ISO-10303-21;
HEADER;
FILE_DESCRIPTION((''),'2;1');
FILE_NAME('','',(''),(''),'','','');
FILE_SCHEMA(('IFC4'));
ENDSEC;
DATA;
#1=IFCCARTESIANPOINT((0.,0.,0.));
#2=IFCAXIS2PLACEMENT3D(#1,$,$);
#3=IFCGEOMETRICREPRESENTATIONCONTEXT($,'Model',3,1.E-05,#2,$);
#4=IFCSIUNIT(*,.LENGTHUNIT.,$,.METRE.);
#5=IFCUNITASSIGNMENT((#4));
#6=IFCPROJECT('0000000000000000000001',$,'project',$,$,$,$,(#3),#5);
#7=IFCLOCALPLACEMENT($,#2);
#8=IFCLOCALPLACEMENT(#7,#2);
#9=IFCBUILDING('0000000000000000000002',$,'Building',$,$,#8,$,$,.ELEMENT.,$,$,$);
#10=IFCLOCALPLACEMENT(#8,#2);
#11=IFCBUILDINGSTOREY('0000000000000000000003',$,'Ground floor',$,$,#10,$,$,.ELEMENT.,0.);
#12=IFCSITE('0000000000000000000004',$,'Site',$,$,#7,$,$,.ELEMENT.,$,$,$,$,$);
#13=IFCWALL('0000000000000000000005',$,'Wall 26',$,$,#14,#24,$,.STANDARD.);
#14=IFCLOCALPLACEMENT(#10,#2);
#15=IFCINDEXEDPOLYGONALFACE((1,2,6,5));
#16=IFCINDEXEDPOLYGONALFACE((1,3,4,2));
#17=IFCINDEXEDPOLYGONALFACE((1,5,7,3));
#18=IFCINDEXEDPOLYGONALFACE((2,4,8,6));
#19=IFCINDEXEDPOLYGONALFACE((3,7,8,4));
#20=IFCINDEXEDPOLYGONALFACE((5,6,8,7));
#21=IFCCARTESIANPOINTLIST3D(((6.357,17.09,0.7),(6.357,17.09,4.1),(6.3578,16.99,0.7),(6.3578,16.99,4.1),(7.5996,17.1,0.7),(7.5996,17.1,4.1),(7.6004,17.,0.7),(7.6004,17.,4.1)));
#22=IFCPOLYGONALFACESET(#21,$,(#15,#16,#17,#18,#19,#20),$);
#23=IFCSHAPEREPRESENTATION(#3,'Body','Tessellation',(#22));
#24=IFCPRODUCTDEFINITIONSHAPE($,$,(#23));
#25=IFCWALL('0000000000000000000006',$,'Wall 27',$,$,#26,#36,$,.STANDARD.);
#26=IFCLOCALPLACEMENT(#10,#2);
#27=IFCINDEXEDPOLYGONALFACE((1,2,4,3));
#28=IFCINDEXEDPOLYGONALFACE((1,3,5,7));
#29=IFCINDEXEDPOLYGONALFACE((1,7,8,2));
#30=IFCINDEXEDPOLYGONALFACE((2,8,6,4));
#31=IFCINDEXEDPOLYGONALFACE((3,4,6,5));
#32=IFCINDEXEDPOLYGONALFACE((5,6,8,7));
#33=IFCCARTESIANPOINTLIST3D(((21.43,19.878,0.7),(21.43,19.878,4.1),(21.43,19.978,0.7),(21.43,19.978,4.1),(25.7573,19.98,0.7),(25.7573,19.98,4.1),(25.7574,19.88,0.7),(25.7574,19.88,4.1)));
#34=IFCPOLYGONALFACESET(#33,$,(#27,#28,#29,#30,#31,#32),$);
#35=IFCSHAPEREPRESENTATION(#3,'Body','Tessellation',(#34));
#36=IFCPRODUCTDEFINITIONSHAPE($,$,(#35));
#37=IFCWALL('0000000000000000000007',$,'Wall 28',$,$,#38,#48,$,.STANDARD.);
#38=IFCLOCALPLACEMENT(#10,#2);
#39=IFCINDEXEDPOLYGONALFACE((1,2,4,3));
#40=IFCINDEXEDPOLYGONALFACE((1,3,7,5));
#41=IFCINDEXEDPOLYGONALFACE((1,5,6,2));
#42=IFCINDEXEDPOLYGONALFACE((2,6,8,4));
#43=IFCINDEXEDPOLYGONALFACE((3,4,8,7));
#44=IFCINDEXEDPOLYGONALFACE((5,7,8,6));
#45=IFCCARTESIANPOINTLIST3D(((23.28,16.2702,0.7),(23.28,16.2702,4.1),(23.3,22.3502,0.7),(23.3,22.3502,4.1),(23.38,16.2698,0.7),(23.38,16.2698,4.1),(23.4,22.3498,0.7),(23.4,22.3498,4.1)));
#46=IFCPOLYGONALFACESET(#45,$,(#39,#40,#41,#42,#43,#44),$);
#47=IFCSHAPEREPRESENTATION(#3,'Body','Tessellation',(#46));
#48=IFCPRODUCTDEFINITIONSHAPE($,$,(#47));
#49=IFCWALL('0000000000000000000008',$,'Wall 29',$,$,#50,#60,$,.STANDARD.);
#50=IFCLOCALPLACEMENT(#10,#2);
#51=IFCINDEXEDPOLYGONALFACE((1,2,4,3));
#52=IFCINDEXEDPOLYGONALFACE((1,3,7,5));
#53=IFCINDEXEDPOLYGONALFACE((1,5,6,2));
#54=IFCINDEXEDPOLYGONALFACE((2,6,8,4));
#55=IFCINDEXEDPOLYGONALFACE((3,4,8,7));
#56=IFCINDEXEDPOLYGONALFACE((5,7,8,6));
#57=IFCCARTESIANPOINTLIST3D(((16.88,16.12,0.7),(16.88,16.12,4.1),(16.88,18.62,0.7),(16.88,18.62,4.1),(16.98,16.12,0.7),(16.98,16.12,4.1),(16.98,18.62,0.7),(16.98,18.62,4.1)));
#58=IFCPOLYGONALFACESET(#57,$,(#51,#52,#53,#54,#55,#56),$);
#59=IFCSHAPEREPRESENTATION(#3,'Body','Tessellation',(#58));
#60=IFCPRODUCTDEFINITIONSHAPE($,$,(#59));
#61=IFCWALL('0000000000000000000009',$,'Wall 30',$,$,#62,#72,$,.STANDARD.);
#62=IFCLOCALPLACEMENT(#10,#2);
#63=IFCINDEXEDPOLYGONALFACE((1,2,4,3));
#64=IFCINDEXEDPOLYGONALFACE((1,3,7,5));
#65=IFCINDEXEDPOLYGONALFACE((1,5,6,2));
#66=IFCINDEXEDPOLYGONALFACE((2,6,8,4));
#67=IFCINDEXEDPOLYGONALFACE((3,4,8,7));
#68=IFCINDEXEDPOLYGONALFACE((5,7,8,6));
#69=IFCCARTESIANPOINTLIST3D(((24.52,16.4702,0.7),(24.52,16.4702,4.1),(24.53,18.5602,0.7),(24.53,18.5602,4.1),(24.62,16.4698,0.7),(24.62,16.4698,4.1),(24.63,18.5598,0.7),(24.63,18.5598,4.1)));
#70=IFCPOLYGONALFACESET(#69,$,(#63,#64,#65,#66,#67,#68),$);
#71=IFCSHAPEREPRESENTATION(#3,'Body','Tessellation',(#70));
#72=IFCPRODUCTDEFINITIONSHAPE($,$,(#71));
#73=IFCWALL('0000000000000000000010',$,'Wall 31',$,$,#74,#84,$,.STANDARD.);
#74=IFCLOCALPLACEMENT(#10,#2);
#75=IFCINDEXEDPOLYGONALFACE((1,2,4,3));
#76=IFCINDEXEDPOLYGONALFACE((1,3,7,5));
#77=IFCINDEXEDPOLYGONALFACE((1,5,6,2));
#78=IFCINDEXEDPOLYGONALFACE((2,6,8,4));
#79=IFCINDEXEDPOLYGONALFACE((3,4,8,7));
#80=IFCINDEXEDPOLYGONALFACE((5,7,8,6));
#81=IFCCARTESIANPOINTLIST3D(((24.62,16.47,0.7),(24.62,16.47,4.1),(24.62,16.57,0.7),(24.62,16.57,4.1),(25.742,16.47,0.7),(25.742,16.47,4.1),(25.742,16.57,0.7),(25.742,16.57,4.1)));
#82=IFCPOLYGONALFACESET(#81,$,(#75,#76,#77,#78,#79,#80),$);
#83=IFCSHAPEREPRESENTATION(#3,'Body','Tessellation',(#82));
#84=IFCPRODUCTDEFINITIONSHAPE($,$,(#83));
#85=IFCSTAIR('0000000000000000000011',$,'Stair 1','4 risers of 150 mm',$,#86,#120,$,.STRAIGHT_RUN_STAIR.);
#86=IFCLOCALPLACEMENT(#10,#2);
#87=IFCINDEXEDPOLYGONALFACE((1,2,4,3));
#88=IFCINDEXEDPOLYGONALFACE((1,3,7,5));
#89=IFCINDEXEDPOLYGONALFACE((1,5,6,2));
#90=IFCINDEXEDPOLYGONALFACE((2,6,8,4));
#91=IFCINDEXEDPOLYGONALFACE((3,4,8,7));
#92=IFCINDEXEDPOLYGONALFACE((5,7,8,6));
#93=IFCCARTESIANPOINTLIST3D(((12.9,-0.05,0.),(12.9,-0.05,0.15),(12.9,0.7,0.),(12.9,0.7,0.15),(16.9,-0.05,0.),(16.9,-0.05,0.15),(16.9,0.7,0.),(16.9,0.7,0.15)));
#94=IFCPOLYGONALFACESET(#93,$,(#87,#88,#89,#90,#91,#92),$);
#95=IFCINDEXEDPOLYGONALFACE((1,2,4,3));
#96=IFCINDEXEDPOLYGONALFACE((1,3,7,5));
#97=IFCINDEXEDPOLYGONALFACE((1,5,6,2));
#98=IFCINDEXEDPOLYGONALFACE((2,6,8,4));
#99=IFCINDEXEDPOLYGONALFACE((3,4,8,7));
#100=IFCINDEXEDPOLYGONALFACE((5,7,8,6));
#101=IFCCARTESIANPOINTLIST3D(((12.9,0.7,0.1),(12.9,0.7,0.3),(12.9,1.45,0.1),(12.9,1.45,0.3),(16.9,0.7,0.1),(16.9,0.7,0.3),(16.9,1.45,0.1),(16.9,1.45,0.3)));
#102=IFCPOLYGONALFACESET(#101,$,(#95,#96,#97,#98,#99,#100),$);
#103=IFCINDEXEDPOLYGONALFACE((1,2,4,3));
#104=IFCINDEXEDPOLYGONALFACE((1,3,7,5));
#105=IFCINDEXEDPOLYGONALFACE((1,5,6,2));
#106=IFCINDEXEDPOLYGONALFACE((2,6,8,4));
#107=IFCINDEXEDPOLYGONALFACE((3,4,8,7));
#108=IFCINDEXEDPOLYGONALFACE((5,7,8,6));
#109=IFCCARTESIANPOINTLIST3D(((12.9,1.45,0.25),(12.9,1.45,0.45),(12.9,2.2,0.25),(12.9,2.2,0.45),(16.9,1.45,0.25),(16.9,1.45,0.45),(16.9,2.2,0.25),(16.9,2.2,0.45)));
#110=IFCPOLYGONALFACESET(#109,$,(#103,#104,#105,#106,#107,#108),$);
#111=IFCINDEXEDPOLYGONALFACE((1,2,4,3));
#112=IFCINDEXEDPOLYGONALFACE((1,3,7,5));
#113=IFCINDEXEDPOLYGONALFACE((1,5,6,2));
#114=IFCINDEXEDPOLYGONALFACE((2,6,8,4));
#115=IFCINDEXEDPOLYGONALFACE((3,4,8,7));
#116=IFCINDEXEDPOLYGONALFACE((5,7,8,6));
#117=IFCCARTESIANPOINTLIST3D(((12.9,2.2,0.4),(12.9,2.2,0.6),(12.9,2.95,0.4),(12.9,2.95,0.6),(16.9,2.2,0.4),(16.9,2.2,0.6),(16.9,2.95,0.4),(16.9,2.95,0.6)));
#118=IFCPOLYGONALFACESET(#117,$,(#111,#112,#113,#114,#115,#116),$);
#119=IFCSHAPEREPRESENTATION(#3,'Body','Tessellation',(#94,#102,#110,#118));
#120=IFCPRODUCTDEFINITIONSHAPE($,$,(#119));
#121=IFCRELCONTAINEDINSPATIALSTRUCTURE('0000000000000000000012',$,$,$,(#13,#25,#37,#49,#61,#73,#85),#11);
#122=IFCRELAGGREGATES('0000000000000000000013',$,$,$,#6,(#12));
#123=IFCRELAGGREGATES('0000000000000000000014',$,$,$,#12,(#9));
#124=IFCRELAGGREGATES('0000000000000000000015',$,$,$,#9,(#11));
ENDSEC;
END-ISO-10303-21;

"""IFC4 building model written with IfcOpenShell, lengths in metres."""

from ifc_helpers import new_model, si_unit, frame, frame_2d, origin, place, context, project, spatial, polyline, rectangle, outline, extrude, element, save


model = new_model("IFC4")

# Units and contexts
model_context = context("Model", 3, precision=1e-05, world=origin())
ifc_project = project(units=[si_unit("LENGTHUNIT", "METRE")], contexts=[model_context])

# Site, building, storey
site_placement = place(None, origin())
site = spatial("IfcSite", under=ifc_project, at=site_placement, Name="Site", CompositionType="ELEMENT")
building_placement = place(site_placement, origin())
building = spatial("IfcBuilding", under=site, at=building_placement, Name="Building", CompositionType="ELEMENT")
storey_placement = place(building_placement, origin())
storey = spatial("IfcBuildingStorey", under=building, at=storey_placement, Name="Ground floor", CompositionType="ELEMENT", Elevation=0.0)

# Walls
wall_1_placement = place(storey_placement, frame((6.3574, 17.04, 0.7), z_axis=(0.0, 0.0, 1.0), x_axis=(0.999968, 0.008054, 0.0)))
element("IfcWall", 1, at=wall_1_placement, inside=storey, Name="Wall 26", PredefinedType="STANDARD", context=model_context, shape_type="SweptSolid", body=[
    extrude(rectangle(XDim=1.2427, YDim=0.1, at=frame_2d((0.6213, 0.0))), origin(), (0.0, 0.0, 1.0), 3.4),
])
wall_2_placement = place(storey_placement, frame((21.43, 19.928, 0.7), z_axis=(0.0, 0.0, 1.0), x_axis=(1.0, 0.000469, 0.0)))
element("IfcWall", 2, at=wall_2_placement, inside=storey, Name="Wall 27", PredefinedType="STANDARD", context=model_context, shape_type="SweptSolid", body=[
    extrude(rectangle(XDim=4.3274, YDim=0.1, at=frame_2d((2.1637, 0.0))), origin(), (0.0, 0.0, 1.0), 3.4),
])
wall_3_placement = place(storey_placement, frame((23.35, 22.35, 0.7), z_axis=(0.0, 0.0, 1.0), x_axis=(-0.003289, -0.999995, 0.0)))
element("IfcWall", 3, at=wall_3_placement, inside=storey, Name="Wall 28", PredefinedType="STANDARD", context=model_context, shape_type="SweptSolid", body=[
    extrude(rectangle(XDim=6.08, YDim=0.1, at=frame_2d((3.04, 0.0))), origin(), (0.0, 0.0, 1.0), 3.4),
])
wall_4_placement = place(storey_placement, frame((16.93, 18.62, 0.7), z_axis=(0.0, 0.0, 1.0), x_axis=(0.0, -1.0, 0.0)))
element("IfcWall", 4, at=wall_4_placement, inside=storey, Name="Wall 29", PredefinedType="STANDARD", context=model_context, shape_type="SweptSolid", body=[
    extrude(rectangle(XDim=2.5, YDim=0.1, at=frame_2d((1.25, 0.0))), origin(), (0.0, 0.0, 1.0), 3.4),
])
wall_5_placement = place(storey_placement, frame((24.58, 18.56, 0.7), z_axis=(0.0, 0.0, 1.0), x_axis=(-0.004785, -0.999989, 0.0)))
element("IfcWall", 5, at=wall_5_placement, inside=storey, Name="Wall 30", PredefinedType="STANDARD", context=model_context, shape_type="SweptSolid", body=[
    extrude(rectangle(XDim=2.09, YDim=0.1, at=frame_2d((1.045, 0.0))), origin(), (0.0, 0.0, 1.0), 3.4),
])
wall_6_placement = place(storey_placement, frame((24.62, 16.52, 0.7), z_axis=(0.0, 0.0, 1.0), x_axis=(1.0, 0.0, 0.0)))
element("IfcWall", 6, at=wall_6_placement, inside=storey, Name="Wall 31", PredefinedType="STANDARD", context=model_context, shape_type="SweptSolid", body=[
    extrude(rectangle(XDim=1.122, YDim=0.1, at=frame_2d((0.561, 0.0))), origin(), (0.0, 0.0, 1.0), 3.4),
])

# Stair
stair_placement = place(storey_placement, frame((14.9, -0.05, 0.0), z_axis=(0.0, 0.0, 1.0), x_axis=(0.0, 1.0, 0.0)))
element("IfcStair", 7, at=stair_placement, inside=storey, Name="Stair 1", Description="4 risers of 150 mm", PredefinedType="STRAIGHT_RUN_STAIR", context=model_context, shape_type="SweptSolid", body=[
    extrude(outline(polyline([(0.0, -2.0), (0.75, -2.0), (0.75, 2.0), (0.0, 2.0), (0.0, -2.0)])), origin(), (0.0, 0.0, 1.0), 0.15),
    extrude(outline(polyline([(0.75, -2.0), (1.5, -2.0), (1.5, 2.0), (0.75, 2.0), (0.75, -2.0)])), frame((0.0, 0.0, 0.1)), (0.0, 0.0, 1.0), 0.2),
    extrude(outline(polyline([(1.5, -2.0), (2.25, -2.0), (2.25, 2.0), (1.5, 2.0), (1.5, -2.0)])), frame((0.0, 0.0, 0.25)), (0.0, 0.0, 1.0), 0.2),
    extrude(outline(polyline([(2.25, -2.0), (3.0, -2.0), (3.0, 2.0), (2.25, 2.0), (2.25, -2.0)])), frame((0.0, 0.0, 0.4)), (0.0, 0.0, 1.0), 0.2),
])

save(model, "model.ifc")
